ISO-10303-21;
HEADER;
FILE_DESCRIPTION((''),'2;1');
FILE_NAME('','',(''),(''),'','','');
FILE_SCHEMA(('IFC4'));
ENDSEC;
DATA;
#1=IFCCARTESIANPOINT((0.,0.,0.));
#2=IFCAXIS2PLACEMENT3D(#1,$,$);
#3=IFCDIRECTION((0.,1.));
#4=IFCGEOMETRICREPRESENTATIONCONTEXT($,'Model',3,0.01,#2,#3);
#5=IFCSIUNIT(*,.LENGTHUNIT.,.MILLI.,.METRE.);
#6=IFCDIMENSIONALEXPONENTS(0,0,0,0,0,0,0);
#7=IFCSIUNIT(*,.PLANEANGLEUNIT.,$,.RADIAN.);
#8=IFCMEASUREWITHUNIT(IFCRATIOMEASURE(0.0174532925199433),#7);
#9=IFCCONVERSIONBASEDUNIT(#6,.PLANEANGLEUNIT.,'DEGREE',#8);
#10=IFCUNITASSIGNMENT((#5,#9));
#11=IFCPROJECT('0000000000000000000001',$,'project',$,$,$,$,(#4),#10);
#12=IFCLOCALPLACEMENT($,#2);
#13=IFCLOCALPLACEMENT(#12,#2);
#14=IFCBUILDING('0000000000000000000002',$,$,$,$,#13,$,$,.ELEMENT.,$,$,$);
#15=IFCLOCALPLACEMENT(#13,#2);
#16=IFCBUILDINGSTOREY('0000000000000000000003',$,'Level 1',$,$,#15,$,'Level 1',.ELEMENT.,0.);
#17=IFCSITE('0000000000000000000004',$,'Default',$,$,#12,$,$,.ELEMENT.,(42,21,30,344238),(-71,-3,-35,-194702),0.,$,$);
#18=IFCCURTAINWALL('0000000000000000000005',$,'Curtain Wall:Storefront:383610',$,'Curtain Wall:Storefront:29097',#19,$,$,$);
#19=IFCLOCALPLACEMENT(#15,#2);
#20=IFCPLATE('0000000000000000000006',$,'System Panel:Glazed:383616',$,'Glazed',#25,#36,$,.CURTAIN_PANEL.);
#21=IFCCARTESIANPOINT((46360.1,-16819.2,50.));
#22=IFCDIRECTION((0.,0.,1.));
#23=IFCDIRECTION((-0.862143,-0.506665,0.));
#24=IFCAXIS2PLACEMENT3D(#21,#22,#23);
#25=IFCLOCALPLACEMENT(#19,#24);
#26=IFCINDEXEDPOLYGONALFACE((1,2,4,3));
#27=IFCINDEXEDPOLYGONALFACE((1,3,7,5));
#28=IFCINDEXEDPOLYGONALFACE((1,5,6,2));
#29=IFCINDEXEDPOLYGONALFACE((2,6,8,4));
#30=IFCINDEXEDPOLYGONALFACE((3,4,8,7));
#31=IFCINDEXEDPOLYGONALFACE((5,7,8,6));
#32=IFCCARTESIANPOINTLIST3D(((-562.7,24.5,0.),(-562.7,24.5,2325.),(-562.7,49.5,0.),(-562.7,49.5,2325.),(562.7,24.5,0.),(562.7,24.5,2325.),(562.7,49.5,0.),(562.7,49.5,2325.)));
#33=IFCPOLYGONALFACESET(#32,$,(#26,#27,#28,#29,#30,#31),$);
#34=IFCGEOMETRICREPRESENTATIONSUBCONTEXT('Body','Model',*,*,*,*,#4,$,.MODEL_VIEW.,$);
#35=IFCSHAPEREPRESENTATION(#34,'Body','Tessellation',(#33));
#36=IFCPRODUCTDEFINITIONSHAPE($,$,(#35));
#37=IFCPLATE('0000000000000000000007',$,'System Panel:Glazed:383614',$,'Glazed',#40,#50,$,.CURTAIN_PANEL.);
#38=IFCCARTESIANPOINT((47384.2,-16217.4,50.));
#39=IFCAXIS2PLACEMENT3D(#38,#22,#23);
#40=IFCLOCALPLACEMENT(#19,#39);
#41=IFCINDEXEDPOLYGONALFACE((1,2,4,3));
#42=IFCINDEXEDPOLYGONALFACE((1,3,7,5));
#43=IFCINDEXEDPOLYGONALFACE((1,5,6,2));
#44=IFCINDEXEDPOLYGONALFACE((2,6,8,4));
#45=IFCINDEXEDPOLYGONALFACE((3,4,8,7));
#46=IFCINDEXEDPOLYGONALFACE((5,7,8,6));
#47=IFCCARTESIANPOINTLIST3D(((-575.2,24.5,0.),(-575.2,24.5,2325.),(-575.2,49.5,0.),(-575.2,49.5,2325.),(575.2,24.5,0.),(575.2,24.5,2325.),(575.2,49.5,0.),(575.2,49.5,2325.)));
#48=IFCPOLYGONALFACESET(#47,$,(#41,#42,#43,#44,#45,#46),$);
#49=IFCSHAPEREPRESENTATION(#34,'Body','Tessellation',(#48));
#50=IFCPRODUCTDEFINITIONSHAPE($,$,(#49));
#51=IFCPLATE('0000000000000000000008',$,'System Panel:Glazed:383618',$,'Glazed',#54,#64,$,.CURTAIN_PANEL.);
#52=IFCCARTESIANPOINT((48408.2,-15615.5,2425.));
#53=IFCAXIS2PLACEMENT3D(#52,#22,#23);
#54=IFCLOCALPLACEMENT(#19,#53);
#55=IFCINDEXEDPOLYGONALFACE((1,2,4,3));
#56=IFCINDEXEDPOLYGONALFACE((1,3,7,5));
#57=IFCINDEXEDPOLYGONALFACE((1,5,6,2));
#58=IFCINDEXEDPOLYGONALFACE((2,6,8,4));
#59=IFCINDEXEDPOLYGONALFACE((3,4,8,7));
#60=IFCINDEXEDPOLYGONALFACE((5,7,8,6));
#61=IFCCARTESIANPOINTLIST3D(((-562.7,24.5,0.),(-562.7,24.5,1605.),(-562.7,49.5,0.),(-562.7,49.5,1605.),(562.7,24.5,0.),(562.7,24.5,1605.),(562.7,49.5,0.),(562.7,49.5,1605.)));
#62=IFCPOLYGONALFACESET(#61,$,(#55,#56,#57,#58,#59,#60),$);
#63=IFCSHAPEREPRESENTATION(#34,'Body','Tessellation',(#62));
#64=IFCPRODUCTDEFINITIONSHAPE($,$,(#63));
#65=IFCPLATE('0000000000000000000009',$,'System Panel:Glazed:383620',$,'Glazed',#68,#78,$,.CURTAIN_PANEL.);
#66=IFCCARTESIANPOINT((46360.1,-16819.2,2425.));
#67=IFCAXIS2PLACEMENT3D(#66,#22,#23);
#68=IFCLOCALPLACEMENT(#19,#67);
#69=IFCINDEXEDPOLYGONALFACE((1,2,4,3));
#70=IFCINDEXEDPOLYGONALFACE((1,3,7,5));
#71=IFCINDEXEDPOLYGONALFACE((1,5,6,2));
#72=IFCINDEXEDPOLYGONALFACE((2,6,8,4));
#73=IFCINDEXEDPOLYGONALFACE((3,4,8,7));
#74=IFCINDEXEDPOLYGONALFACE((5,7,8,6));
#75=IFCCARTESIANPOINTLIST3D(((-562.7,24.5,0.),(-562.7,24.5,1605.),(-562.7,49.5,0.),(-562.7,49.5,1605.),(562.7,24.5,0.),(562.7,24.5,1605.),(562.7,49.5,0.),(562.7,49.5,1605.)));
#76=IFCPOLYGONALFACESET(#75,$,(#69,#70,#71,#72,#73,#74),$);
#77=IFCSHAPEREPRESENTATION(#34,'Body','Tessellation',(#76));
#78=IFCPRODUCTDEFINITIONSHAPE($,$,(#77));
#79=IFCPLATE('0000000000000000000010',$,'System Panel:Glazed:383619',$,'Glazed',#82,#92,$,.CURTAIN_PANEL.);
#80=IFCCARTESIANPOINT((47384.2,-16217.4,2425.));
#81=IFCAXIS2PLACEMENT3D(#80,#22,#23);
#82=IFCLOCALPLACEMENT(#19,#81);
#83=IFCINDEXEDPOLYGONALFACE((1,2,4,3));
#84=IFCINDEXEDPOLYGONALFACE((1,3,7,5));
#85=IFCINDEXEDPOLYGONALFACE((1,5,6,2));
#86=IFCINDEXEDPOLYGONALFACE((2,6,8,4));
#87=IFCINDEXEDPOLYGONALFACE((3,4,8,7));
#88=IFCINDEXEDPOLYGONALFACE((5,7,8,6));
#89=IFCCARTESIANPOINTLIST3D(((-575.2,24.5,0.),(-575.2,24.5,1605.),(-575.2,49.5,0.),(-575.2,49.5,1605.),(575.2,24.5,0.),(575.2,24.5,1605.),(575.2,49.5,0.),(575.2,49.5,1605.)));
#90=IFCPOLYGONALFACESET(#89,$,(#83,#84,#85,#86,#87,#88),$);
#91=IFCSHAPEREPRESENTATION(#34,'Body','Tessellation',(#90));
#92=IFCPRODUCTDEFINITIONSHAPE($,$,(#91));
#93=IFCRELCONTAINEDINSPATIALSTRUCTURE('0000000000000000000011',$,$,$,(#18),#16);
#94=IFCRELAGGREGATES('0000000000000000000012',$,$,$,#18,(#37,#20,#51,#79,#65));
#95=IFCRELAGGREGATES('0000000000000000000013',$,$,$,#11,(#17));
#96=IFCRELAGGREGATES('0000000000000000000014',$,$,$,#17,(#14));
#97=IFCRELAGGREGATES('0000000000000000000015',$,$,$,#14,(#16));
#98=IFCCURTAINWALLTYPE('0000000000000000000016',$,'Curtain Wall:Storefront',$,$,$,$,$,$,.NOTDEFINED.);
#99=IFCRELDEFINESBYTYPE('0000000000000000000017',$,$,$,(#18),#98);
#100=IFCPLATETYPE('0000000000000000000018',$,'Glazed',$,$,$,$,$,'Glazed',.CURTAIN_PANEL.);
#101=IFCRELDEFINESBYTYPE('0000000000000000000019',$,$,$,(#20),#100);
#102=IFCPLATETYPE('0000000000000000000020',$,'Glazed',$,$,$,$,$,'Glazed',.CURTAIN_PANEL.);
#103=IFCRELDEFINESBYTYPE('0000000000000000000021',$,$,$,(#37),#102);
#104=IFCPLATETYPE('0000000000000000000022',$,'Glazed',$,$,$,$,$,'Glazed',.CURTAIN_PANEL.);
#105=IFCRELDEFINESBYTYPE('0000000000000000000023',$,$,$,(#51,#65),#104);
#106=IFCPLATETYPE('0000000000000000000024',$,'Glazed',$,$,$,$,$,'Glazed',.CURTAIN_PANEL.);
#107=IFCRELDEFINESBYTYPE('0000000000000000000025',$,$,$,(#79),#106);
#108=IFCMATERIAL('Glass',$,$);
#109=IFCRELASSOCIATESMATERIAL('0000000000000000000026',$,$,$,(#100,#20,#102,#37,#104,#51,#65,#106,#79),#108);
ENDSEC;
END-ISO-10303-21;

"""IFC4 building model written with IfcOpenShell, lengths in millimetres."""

from ifc_helpers import new_model, entity, si_unit, converted_unit, direction, frame, frame_2d, origin, place, context, subcontext, project, spatial, rectangle, extrude, source, transform, mapped, material, type_object, type_shapes, element, aggregate, save


model = new_model("IFC4")

# Units and contexts
model_context = context("Model", 3, precision=0.01, world=origin(), true_north=direction((0.0, 1.0)))
body_context = subcontext(model_context, "Body", "Model", "MODEL_VIEW")
ifc_project = project(units=[si_unit("LENGTHUNIT", "METRE", prefix="MILLI"), converted_unit("PLANEANGLEUNIT", "DEGREE", entity("IfcRatioMeasure", 0.0174532925199433), si_unit("PLANEANGLEUNIT", "RADIAN"), dimensions=[0, 0, 0, 0, 0, 0, 0])], contexts=[model_context])

# Site, building, storey
site_placement = place(None, origin())
site = spatial("IfcSite", under=ifc_project, at=site_placement, Name="Default", CompositionType="ELEMENT", RefLatitude=(42, 21, 30, 344238), RefLongitude=(-71, -3, -35, -194702), RefElevation=0.0)
building_placement = place(site_placement, origin())
building = spatial("IfcBuilding", under=site, at=building_placement, CompositionType="ELEMENT")
storey_placement = place(building_placement, origin())
storey = spatial("IfcBuildingStorey", under=building, at=storey_placement, Name="Level 1", LongName="Level 1", CompositionType="ELEMENT", Elevation=0.0)

# Curtain wall, plates
curtain_wall_type = type_object("IfcCurtainWallType", Name="Curtain Wall:Storefront", PredefinedType="NOTDEFINED")
ifc_material_1 = material(Name="Glass")
curtain_wall_1_placement = place(storey_placement, origin())
curtain_wall_1 = element("IfcCurtainWall", 1, at=curtain_wall_1_placement, inside=storey, type_object=curtain_wall_type, Name="Curtain Wall:Storefront:383610", ObjectType="Curtain Wall:Storefront:29097")
plate_type_1 = type_object("IfcPlateType", Name="Glazed", ElementType="Glazed", PredefinedType="CURTAIN_PANEL", material=ifc_material_1)
shared_shape_1 = source(origin(), body_context, "Body", "SweptSolid", [
    extrude(rectangle(XDim=25.0, YDim=1125.3, at=frame_2d((0.0, 0.0), x_axis=(1.0, 0.0))), frame((0.0, 37.0, 0.0), z_axis=(0.0, 0.0, 1.0), x_axis=(0.0, 1.0, 0.0)), (0.0, 0.0, 1.0), 2325.0),
])
type_shapes(plate_type_1, [shared_shape_1])
plate_1_placement = place(curtain_wall_1_placement, frame((46360.1, -16819.2, 50.0), z_axis=(0.0, 0.0, 1.0), x_axis=(-0.862143, -0.506665, 0.0)))
plate_1 = element("IfcPlate", 2, at=plate_1_placement, type_object=plate_type_1, material=ifc_material_1, Name="System Panel:Glazed:383616", ObjectType="Glazed", PredefinedType="CURTAIN_PANEL", context=body_context, shape_type="MappedRepresentation", body=[
    mapped(shared_shape_1, transform((0.0, 0.0, 0.0), scale=1.0)),
])
plate_type_2 = type_object("IfcPlateType", Name="Glazed", ElementType="Glazed", PredefinedType="CURTAIN_PANEL", material=ifc_material_1)
shared_shape_2 = source(origin(), body_context, "Body", "SweptSolid", [
    extrude(rectangle(XDim=25.0, YDim=1150.3, at=frame_2d((0.0, 0.0), x_axis=(1.0, 0.0))), frame((0.0, 37.0, 0.0), z_axis=(0.0, 0.0, 1.0), x_axis=(0.0, 1.0, 0.0)), (0.0, 0.0, 1.0), 2325.0),
])
type_shapes(plate_type_2, [shared_shape_2])
plate_2_placement = place(curtain_wall_1_placement, frame((47384.2, -16217.4, 50.0), z_axis=(0.0, 0.0, 1.0), x_axis=(-0.862143, -0.506665, 0.0)))
plate_2 = element("IfcPlate", 3, at=plate_2_placement, type_object=plate_type_2, material=ifc_material_1, Name="System Panel:Glazed:383614", ObjectType="Glazed", PredefinedType="CURTAIN_PANEL", context=body_context, shape_type="MappedRepresentation", body=[
    mapped(shared_shape_2, transform((0.0, 0.0, 0.0), scale=1.0)),
])
plate_type_3 = type_object("IfcPlateType", Name="Glazed", ElementType="Glazed", PredefinedType="CURTAIN_PANEL", material=ifc_material_1)
shared_shape_3 = source(origin(), body_context, "Body", "SweptSolid", [
    extrude(rectangle(XDim=25.0, YDim=1125.3, at=frame_2d((0.0, 0.0), x_axis=(1.0, 0.0))), frame((0.0, 37.0, 0.0), z_axis=(0.0, 0.0, 1.0), x_axis=(0.0, 1.0, 0.0)), (0.0, 0.0, 1.0), 1605.0),
])
type_shapes(plate_type_3, [shared_shape_3])
plate_3_placement = place(curtain_wall_1_placement, frame((48408.2, -15615.5, 2425.0), z_axis=(0.0, 0.0, 1.0), x_axis=(-0.862143, -0.506665, 0.0)))
plate_3 = element("IfcPlate", 4, at=plate_3_placement, type_object=plate_type_3, material=ifc_material_1, Name="System Panel:Glazed:383618", ObjectType="Glazed", PredefinedType="CURTAIN_PANEL", context=body_context, shape_type="MappedRepresentation", body=[
    mapped(shared_shape_3, transform((0.0, 0.0, 0.0), scale=1.0)),
])
plate_4_placement = place(curtain_wall_1_placement, frame((46360.1, -16819.2, 2425.0), z_axis=(0.0, 0.0, 1.0), x_axis=(-0.862143, -0.506665, 0.0)))
plate_4 = element("IfcPlate", 5, at=plate_4_placement, type_object=plate_type_3, material=ifc_material_1, Name="System Panel:Glazed:383620", ObjectType="Glazed", PredefinedType="CURTAIN_PANEL", context=body_context, shape_type="MappedRepresentation", body=[
    mapped(shared_shape_3, transform((0.0, 0.0, 0.0), scale=1.0)),
])
plate_type_4 = type_object("IfcPlateType", Name="Glazed", ElementType="Glazed", PredefinedType="CURTAIN_PANEL", material=ifc_material_1)
shared_shape_4 = source(origin(), body_context, "Body", "SweptSolid", [
    extrude(rectangle(XDim=25.0, YDim=1150.3, at=frame_2d((0.0, 0.0), x_axis=(1.0, 0.0))), frame((0.0, 37.0, 0.0), z_axis=(0.0, 0.0, 1.0), x_axis=(0.0, 1.0, 0.0)), (0.0, 0.0, 1.0), 1605.0),
])
type_shapes(plate_type_4, [shared_shape_4])
plate_5_placement = place(curtain_wall_1_placement, frame((47384.2, -16217.4, 2425.0), z_axis=(0.0, 0.0, 1.0), x_axis=(-0.862143, -0.506665, 0.0)))
plate_5 = element("IfcPlate", 6, at=plate_5_placement, type_object=plate_type_4, material=ifc_material_1, Name="System Panel:Glazed:383619", ObjectType="Glazed", PredefinedType="CURTAIN_PANEL", context=body_context, shape_type="MappedRepresentation", body=[
    mapped(shared_shape_4, transform((0.0, 0.0, 0.0), scale=1.0)),
])
aggregate(curtain_wall_1, [plate_2, plate_1, plate_3, plate_5, plate_4])

save(model, "model.ifc")
